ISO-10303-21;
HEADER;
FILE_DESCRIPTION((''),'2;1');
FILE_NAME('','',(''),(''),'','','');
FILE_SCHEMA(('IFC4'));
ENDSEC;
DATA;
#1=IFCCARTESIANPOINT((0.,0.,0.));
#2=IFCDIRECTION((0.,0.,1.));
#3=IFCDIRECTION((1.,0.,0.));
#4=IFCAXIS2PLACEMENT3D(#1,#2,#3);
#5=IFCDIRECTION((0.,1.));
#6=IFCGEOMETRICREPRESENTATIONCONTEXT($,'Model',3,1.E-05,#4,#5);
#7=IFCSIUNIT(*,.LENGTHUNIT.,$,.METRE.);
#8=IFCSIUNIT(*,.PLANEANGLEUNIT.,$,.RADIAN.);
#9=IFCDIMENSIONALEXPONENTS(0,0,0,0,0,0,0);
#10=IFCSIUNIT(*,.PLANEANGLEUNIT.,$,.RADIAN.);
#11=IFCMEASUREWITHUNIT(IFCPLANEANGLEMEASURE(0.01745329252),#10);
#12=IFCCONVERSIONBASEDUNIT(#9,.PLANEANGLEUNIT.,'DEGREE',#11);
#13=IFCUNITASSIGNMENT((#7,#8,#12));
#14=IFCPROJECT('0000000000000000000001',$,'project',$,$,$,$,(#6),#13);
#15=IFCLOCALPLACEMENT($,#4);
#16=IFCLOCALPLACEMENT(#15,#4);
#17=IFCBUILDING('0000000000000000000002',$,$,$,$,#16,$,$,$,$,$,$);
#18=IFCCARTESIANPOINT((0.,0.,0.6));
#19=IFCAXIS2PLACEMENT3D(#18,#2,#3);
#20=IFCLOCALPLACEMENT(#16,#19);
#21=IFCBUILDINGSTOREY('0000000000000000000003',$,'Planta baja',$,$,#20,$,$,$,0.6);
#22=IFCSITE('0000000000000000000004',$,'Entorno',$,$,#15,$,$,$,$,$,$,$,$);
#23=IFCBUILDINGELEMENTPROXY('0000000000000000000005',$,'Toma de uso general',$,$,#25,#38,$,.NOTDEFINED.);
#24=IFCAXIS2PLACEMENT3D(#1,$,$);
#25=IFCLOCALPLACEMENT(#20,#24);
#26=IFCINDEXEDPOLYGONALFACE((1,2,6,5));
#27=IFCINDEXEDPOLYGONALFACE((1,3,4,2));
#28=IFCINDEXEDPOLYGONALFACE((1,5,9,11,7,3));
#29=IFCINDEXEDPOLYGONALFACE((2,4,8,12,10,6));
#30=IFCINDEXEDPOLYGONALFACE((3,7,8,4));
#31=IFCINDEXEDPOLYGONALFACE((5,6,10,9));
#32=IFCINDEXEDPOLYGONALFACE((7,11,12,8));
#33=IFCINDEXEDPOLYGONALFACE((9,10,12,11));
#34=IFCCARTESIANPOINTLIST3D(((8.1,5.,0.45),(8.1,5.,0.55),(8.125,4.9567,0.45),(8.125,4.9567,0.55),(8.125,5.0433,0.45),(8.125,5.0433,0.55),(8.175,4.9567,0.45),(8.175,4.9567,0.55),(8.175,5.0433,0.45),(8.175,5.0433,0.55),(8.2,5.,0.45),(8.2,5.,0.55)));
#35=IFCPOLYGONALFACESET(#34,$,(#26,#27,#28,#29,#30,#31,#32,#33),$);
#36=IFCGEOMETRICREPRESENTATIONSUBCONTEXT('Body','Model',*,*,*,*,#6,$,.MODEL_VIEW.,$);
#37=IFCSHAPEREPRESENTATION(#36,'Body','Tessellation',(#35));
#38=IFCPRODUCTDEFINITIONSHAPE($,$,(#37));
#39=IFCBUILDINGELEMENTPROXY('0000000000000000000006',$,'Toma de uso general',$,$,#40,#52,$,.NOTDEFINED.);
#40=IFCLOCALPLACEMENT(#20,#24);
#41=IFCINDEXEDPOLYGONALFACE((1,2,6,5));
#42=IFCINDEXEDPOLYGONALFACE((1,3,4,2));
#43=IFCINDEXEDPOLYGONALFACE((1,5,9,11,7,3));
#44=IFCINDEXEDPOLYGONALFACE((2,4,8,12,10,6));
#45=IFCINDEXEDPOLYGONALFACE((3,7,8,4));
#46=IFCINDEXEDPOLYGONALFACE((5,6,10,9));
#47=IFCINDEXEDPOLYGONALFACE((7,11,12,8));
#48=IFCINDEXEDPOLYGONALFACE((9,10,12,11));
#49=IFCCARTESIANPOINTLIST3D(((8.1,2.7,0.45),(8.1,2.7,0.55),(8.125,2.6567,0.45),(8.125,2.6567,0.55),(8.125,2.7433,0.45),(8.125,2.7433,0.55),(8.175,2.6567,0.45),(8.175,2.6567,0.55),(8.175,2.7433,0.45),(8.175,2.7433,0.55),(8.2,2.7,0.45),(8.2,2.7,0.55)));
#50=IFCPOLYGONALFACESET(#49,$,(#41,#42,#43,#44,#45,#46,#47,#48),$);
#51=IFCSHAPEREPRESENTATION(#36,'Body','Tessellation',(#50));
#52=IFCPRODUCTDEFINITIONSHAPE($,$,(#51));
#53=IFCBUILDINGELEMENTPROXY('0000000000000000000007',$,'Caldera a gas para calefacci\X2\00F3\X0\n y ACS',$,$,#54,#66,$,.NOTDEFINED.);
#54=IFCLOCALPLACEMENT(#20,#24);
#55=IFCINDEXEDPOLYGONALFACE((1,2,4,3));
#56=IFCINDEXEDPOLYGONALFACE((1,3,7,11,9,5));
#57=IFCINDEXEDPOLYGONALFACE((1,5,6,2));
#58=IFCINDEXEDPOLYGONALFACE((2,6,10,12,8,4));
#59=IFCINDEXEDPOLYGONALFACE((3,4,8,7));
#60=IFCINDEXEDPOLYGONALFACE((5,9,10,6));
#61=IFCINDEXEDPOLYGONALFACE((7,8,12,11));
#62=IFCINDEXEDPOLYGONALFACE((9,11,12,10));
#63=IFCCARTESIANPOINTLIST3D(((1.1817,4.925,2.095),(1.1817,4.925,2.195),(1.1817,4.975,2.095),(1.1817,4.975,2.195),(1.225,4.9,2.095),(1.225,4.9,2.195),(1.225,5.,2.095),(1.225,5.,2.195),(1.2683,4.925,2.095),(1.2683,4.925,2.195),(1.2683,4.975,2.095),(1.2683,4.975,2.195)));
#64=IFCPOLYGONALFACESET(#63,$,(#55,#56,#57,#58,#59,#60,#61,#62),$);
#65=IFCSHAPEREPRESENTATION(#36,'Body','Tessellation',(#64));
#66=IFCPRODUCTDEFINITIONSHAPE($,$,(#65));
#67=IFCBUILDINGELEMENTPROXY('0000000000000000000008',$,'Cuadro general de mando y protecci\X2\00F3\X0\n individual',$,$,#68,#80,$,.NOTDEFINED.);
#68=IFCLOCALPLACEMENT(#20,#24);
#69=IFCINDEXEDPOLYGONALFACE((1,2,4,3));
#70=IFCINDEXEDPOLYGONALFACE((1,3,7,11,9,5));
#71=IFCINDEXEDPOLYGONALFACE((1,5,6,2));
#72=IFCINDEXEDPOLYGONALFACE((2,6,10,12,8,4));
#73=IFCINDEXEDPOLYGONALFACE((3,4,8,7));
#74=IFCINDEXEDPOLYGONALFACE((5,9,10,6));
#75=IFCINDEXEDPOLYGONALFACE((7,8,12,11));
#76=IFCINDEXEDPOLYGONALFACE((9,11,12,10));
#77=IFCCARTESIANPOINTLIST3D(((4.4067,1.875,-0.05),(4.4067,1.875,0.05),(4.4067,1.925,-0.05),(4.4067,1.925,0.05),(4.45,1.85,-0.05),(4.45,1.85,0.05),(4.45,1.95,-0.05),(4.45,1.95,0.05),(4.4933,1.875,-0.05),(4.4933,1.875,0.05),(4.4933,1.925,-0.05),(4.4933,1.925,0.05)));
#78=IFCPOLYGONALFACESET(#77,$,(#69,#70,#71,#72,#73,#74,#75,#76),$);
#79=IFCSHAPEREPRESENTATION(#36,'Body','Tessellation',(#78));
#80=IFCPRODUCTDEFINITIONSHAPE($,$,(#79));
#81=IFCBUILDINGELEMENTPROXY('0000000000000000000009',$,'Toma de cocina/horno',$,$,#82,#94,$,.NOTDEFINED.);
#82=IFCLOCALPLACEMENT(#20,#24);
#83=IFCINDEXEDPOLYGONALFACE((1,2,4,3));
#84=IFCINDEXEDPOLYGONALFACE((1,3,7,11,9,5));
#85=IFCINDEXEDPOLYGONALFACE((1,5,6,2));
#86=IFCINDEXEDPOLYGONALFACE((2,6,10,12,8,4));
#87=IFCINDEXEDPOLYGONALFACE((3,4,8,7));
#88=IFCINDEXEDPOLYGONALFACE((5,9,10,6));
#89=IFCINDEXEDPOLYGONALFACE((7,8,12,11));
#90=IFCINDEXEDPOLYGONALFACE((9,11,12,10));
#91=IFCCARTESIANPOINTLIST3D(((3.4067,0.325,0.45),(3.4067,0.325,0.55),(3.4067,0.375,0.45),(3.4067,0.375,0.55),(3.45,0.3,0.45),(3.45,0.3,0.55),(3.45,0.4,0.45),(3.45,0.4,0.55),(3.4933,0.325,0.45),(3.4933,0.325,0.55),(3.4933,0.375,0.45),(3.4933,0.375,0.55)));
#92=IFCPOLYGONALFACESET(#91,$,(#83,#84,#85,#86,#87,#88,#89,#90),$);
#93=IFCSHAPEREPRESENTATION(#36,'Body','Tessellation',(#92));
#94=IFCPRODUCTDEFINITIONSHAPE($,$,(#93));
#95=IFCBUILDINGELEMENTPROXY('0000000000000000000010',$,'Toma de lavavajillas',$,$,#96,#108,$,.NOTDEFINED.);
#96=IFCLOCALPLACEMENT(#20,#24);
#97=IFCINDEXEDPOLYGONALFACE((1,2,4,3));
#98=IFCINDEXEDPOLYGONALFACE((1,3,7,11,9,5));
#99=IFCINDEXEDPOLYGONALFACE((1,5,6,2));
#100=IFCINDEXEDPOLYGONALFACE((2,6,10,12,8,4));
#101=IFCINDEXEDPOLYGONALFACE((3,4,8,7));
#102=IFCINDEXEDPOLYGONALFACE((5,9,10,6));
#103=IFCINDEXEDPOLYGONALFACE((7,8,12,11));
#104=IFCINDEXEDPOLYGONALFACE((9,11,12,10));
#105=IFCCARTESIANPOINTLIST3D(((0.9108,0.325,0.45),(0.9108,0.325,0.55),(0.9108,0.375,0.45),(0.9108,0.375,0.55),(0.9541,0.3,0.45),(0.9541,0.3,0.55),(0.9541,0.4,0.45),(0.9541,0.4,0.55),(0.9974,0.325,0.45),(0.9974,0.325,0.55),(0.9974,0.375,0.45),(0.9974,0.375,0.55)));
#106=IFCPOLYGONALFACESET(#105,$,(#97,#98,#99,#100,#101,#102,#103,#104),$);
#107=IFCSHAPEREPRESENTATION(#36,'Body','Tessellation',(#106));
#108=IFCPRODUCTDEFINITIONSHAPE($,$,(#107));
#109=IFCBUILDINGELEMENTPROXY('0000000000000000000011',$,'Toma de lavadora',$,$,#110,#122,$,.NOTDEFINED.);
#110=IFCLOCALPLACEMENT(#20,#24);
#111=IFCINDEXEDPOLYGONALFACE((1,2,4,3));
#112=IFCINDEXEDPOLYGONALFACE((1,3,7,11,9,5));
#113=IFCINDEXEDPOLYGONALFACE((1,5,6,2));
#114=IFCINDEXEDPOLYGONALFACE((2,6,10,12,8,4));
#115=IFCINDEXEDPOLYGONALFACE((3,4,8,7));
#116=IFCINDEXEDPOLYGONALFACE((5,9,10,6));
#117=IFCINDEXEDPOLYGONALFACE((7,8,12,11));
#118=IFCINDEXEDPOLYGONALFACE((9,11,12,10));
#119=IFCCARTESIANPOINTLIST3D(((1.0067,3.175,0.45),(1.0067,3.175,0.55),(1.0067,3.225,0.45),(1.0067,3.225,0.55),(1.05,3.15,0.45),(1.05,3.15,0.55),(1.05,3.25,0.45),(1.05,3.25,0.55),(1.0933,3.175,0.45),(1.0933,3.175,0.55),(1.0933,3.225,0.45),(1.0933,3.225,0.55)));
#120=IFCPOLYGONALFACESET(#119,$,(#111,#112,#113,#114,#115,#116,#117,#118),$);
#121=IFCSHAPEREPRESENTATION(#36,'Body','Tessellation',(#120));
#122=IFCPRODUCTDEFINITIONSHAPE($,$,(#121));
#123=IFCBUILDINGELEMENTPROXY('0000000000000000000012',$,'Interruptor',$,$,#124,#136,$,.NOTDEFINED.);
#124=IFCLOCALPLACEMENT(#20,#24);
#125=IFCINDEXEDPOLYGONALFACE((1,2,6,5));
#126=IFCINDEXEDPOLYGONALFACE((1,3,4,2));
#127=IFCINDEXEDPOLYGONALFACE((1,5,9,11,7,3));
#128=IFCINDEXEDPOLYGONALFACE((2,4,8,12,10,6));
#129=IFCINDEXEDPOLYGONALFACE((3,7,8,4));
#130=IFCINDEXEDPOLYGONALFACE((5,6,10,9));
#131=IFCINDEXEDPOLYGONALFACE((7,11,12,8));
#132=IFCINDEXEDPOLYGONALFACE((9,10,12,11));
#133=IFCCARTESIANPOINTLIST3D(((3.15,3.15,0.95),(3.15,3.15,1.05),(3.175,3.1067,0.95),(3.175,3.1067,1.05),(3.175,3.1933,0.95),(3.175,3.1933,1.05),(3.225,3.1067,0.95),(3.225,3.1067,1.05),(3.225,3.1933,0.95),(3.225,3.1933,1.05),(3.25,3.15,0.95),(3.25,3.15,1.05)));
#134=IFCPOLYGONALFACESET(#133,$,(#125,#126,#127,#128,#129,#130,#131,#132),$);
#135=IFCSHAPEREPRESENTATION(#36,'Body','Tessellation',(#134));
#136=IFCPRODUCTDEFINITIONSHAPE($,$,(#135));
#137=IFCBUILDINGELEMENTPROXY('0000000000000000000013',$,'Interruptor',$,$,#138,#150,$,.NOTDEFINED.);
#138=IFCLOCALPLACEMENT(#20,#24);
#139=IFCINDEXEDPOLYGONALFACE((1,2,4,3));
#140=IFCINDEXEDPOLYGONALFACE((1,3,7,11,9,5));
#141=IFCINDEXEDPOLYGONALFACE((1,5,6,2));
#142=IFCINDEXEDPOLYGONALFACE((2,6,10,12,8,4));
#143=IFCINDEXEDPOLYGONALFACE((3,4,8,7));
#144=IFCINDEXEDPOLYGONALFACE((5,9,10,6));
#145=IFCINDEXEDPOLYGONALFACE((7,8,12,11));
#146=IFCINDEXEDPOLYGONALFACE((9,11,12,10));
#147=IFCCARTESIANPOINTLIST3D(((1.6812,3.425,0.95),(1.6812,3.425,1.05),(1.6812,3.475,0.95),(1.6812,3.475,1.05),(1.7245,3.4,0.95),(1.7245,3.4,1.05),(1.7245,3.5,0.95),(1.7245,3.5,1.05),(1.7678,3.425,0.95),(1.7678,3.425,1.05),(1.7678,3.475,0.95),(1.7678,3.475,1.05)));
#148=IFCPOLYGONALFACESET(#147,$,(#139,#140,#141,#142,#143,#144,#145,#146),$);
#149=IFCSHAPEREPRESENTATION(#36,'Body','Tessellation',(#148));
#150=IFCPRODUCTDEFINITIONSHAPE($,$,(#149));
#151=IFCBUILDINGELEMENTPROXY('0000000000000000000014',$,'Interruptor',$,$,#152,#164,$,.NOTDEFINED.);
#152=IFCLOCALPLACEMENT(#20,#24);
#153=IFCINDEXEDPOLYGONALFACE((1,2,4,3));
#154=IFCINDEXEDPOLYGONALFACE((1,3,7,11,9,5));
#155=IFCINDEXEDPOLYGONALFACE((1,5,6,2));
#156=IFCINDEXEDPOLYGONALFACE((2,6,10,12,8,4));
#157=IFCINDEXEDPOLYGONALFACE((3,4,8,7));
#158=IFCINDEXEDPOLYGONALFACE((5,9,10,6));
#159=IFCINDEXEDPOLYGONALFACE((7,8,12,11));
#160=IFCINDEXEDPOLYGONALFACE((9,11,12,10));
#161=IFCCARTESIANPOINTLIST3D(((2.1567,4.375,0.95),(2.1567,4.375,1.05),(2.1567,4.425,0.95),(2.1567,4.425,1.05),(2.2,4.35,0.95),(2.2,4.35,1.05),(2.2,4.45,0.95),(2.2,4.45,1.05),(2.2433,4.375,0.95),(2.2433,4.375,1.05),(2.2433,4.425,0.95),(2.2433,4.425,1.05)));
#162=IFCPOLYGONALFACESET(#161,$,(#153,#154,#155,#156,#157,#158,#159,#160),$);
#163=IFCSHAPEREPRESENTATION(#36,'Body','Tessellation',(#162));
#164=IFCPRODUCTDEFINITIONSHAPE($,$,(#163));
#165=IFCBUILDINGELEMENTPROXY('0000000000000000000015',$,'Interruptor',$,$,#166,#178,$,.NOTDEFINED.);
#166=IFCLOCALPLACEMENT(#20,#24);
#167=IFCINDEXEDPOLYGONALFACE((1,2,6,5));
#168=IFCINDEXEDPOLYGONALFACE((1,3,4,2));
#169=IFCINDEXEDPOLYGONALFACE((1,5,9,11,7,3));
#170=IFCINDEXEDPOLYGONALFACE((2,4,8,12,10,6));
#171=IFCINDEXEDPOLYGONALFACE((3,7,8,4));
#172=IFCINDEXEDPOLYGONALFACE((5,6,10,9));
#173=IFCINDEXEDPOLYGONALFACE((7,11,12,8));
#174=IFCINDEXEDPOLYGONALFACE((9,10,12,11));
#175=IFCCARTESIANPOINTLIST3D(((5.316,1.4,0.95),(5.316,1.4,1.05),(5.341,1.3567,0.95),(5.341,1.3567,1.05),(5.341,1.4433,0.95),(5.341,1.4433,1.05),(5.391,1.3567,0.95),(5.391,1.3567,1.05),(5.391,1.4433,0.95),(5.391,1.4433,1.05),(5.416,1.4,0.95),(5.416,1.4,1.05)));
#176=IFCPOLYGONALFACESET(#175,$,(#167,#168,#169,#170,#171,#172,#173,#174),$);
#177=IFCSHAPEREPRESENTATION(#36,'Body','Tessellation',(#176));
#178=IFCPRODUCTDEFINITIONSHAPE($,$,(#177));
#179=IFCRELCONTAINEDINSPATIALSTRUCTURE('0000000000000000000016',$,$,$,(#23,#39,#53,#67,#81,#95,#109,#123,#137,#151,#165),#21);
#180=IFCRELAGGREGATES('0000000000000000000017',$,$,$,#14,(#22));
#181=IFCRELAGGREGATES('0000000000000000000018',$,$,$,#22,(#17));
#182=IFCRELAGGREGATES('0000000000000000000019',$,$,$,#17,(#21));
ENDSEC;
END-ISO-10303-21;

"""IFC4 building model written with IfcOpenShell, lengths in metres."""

from ifc_helpers import new_model, entity, si_unit, converted_unit, direction, frame, origin_with_axes, place, context, subcontext, project, spatial, polyline, outline, extrude, source, transform, mapped, element, save


model = new_model("IFC4")

# Units and contexts
model_context = context("Model", 3, precision=1e-05, world=origin_with_axes(), true_north=direction((0.0, 1.0)))
body_context = subcontext(model_context, "Body", "Model", "MODEL_VIEW")
ifc_project = project(units=[si_unit("LENGTHUNIT", "METRE"), si_unit("PLANEANGLEUNIT", "RADIAN"), converted_unit("PLANEANGLEUNIT", "DEGREE", entity("IfcPlaneAngleMeasure", 0.01745329252), si_unit("PLANEANGLEUNIT", "RADIAN"), dimensions=[0, 0, 0, 0, 0, 0, 0])], contexts=[model_context])

# Site, building, storey
site_placement = place(None, origin_with_axes())
site = spatial("IfcSite", under=ifc_project, at=site_placement, Name="Entorno")
building_placement = place(site_placement, origin_with_axes())
building = spatial("IfcBuilding", under=site, at=building_placement)
storey_placement = place(building_placement, frame((0.0, 0.0, 0.6), z_axis=(0.0, 0.0, 1.0), x_axis=(1.0, 0.0, 0.0)))
storey = spatial("IfcBuildingStorey", under=building, at=storey_placement, Name="Planta baja", Elevation=0.6)

# Building element proxies
shared_shape_1 = source(origin_with_axes(), body_context, "Body", "SolidModel", [
    extrude(outline(polyline([(0.05, 0.0), (0.025, 0.0433), (-0.025, 0.0433), (-0.05, 0.0), (-0.025, -0.0433), (0.025, -0.0433), (0.05, 0.0)])), frame((0.0, 0.0, -0.05), z_axis=(0.0, 0.0, 1.0), x_axis=(1.0, 0.0, 0.0)), (0.0, 0.0, 1.0), 0.1),
])
proxy_1_placement = place(storey_placement, frame((0.0, 0.0, -0.6), z_axis=(0.0, 0.0, 1.0), x_axis=(1.0, 0.0, 0.0)))
element("IfcBuildingElementProxy", 1, at=proxy_1_placement, inside=storey, Name="Toma de uso general", PredefinedType="NOTDEFINED", context=body_context, shape_type="Brep", body=[
    mapped(shared_shape_1, transform((8.15, 5.0, 1.1), x_axis=(-1.0, 0.0, 0.0), y_axis=(0.0, -1.0, 0.0), z_axis=(0.0, 0.0, 1.0))),
])
proxy_2_placement = place(storey_placement, frame((0.0, 0.0, -0.6), z_axis=(0.0, 0.0, 1.0), x_axis=(1.0, 0.0, 0.0)))
element("IfcBuildingElementProxy", 2, at=proxy_2_placement, inside=storey, Name="Toma de uso general", PredefinedType="NOTDEFINED", context=body_context, shape_type="Brep", body=[
    mapped(shared_shape_1, transform((8.15, 2.7, 1.1), x_axis=(-1.0, 0.0, 0.0), y_axis=(0.0, -1.0, 0.0), z_axis=(0.0, 0.0, 1.0))),
])
shared_shape_2 = source(origin_with_axes(), body_context, "Body", "SolidModel", [
    extrude(outline(polyline([(0.05, 0.0), (0.025, 0.0433), (-0.025, 0.0433), (-0.05, 0.0), (-0.025, -0.0433), (0.025, -0.0433), (0.05, 0.0)])), frame((0.0, 0.0, -0.05), z_axis=(0.0, 0.0, 1.0), x_axis=(1.0, 0.0, 0.0)), (0.0, 0.0, 1.0), 0.1),
])
proxy_3_placement = place(storey_placement, frame((0.0, 0.0, -0.6), z_axis=(0.0, 0.0, 1.0), x_axis=(1.0, 0.0, 0.0)))
element("IfcBuildingElementProxy", 3, at=proxy_3_placement, inside=storey, Name="Caldera a gas para calefacción y ACS", PredefinedType="NOTDEFINED", context=body_context, shape_type="Brep", body=[
    mapped(shared_shape_2, transform((1.225, 4.95, 2.745), x_axis=(0.0, 1.0, 0.0), y_axis=(-1.0, 0.0, 0.0), z_axis=(0.0, 0.0, 1.0))),
])
shared_shape_3 = source(origin_with_axes(), body_context, "Body", "SolidModel", [
    extrude(outline(polyline([(0.05, 0.0), (0.025, 0.0433), (-0.025, 0.0433), (-0.05, 0.0), (-0.025, -0.0433), (0.025, -0.0433), (0.05, 0.0)])), frame((0.0, 0.0, -0.05), z_axis=(0.0, 0.0, 1.0), x_axis=(1.0, 0.0, 0.0)), (0.0, 0.0, 1.0), 0.1),
])
proxy_4_placement = place(storey_placement, frame((0.0, 0.0, -0.6), z_axis=(0.0, 0.0, 1.0), x_axis=(1.0, 0.0, 0.0)))
element("IfcBuildingElementProxy", 4, at=proxy_4_placement, inside=storey, Name="Cuadro general de mando y protección individual", PredefinedType="NOTDEFINED", context=body_context, shape_type="Brep", body=[
    mapped(shared_shape_3, transform((4.45, 1.9, 0.6), x_axis=(0.0, -1.0, 0.0), y_axis=(1.0, 0.0, 0.0), z_axis=(0.0, 0.0, 1.0))),
])
shared_shape_4 = source(origin_with_axes(), body_context, "Body", "SolidModel", [
    extrude(outline(polyline([(0.05, 0.0), (0.025, 0.0433), (-0.025, 0.0433), (-0.05, 0.0), (-0.025, -0.0433), (0.025, -0.0433), (0.05, 0.0)])), frame((0.0, 0.0, -0.05), z_axis=(0.0, 0.0, 1.0), x_axis=(1.0, 0.0, 0.0)), (0.0, 0.0, 1.0), 0.1),
])
proxy_5_placement = place(storey_placement, frame((0.0, 0.0, -0.6), z_axis=(0.0, 0.0, 1.0), x_axis=(1.0, 0.0, 0.0)))
element("IfcBuildingElementProxy", 5, at=proxy_5_placement, inside=storey, Name="Toma de cocina/horno", PredefinedType="NOTDEFINED", context=body_context, shape_type="Brep", body=[
    mapped(shared_shape_4, transform((3.45, 0.35, 1.1), x_axis=(0.0, 1.0, 0.0), y_axis=(-1.0, 0.0, 0.0), z_axis=(0.0, 0.0, 1.0))),
])
shared_shape_5 = source(origin_with_axes(), body_context, "Body", "SolidModel", [
    extrude(outline(polyline([(0.05, 0.0), (0.025, 0.0433), (-0.025, 0.0433), (-0.05, 0.0), (-0.025, -0.0433), (0.025, -0.0433), (0.05, 0.0)])), frame((0.0, 0.0, -0.05), z_axis=(0.0, 0.0, 1.0), x_axis=(1.0, 0.0, 0.0)), (0.0, 0.0, 1.0), 0.1),
])
proxy_6_placement = place(storey_placement, frame((0.0, 0.0, -0.6), z_axis=(0.0, 0.0, 1.0), x_axis=(1.0, 0.0, 0.0)))
element("IfcBuildingElementProxy", 6, at=proxy_6_placement, inside=storey, Name="Toma de lavavajillas", PredefinedType="NOTDEFINED", context=body_context, shape_type="Brep", body=[
    mapped(shared_shape_5, transform((0.9541, 0.35, 1.1), x_axis=(0.0, 1.0, 0.0), y_axis=(-1.0, 0.0, 0.0), z_axis=(0.0, 0.0, 1.0))),
])
shared_shape_6 = source(origin_with_axes(), body_context, "Body", "SolidModel", [
    extrude(outline(polyline([(0.05, 0.0), (0.025, 0.0433), (-0.025, 0.0433), (-0.05, 0.0), (-0.025, -0.0433), (0.025, -0.0433), (0.05, 0.0)])), frame((0.0, 0.0, -0.05), z_axis=(0.0, 0.0, 1.0), x_axis=(1.0, 0.0, 0.0)), (0.0, 0.0, 1.0), 0.1),
])
proxy_7_placement = place(storey_placement, frame((0.0, 0.0, -0.6), z_axis=(0.0, 0.0, 1.0), x_axis=(1.0, 0.0, 0.0)))
element("IfcBuildingElementProxy", 7, at=proxy_7_placement, inside=storey, Name="Toma de lavadora", PredefinedType="NOTDEFINED", context=body_context, shape_type="Brep", body=[
    mapped(shared_shape_6, transform((1.05, 3.2, 1.1), x_axis=(0.0, -1.0, 0.0), y_axis=(1.0, 0.0, 0.0), z_axis=(0.0, 0.0, 1.0))),
])
shared_shape_7 = source(origin_with_axes(), body_context, "Body", "SolidModel", [
    extrude(outline(polyline([(0.05, 0.0), (0.025, 0.0433), (-0.025, 0.0433), (-0.05, 0.0), (-0.025, -0.0433), (0.025, -0.0433), (0.05, 0.0)])), frame((0.0, 0.0, -0.05), z_axis=(0.0, 0.0, 1.0), x_axis=(1.0, 0.0, 0.0)), (0.0, 0.0, 1.0), 0.1),
])
proxy_8_placement = place(storey_placement, frame((0.0, 0.0, -0.6), z_axis=(0.0, 0.0, 1.0), x_axis=(1.0, 0.0, 0.0)))
element("IfcBuildingElementProxy", 8, at=proxy_8_placement, inside=storey, Name="Interruptor", PredefinedType="NOTDEFINED", context=body_context, shape_type="Brep", body=[
    mapped(shared_shape_7, transform((3.2, 3.15, 1.6), x_axis=(1.0, 0.0, 0.0), y_axis=(0.0, 1.0, 0.0), z_axis=(0.0, 0.0, 1.0))),
])
proxy_9_placement = place(storey_placement, frame((0.0, 0.0, -0.6), z_axis=(0.0, 0.0, 1.0), x_axis=(1.0, 0.0, 0.0)))
element("IfcBuildingElementProxy", 9, at=proxy_9_placement, inside=storey, Name="Interruptor", PredefinedType="NOTDEFINED", context=body_context, shape_type="Brep", body=[
    mapped(shared_shape_7, transform((1.7245, 3.45, 1.6), x_axis=(0.0, 1.0, 0.0), y_axis=(-1.0, 0.0, 0.0), z_axis=(0.0, 0.0, 1.0))),
])
proxy_10_placement = place(storey_placement, frame((0.0, 0.0, -0.6), z_axis=(0.0, 0.0, 1.0), x_axis=(1.0, 0.0, 0.0)))
element("IfcBuildingElementProxy", 10, at=proxy_10_placement, inside=storey, Name="Interruptor", PredefinedType="NOTDEFINED", context=body_context, shape_type="Brep", body=[
    mapped(shared_shape_7, transform((2.2, 4.4, 1.6), x_axis=(0.0, 1.0, 0.0), y_axis=(-1.0, 0.0, 0.0), z_axis=(0.0, 0.0, 1.0))),
])
proxy_11_placement = place(storey_placement, frame((0.0, 0.0, -0.6), z_axis=(0.0, 0.0, 1.0), x_axis=(1.0, 0.0, 0.0)))
element("IfcBuildingElementProxy", 11, at=proxy_11_placement, inside=storey, Name="Interruptor", PredefinedType="NOTDEFINED", context=body_context, shape_type="Brep", body=[
    mapped(shared_shape_7, transform((5.366, 1.4, 1.6), x_axis=(-1.0, 0.0, 0.0), y_axis=(0.0, -1.0, 0.0), z_axis=(0.0, 0.0, 1.0))),
])

save(model, "model.ifc")
